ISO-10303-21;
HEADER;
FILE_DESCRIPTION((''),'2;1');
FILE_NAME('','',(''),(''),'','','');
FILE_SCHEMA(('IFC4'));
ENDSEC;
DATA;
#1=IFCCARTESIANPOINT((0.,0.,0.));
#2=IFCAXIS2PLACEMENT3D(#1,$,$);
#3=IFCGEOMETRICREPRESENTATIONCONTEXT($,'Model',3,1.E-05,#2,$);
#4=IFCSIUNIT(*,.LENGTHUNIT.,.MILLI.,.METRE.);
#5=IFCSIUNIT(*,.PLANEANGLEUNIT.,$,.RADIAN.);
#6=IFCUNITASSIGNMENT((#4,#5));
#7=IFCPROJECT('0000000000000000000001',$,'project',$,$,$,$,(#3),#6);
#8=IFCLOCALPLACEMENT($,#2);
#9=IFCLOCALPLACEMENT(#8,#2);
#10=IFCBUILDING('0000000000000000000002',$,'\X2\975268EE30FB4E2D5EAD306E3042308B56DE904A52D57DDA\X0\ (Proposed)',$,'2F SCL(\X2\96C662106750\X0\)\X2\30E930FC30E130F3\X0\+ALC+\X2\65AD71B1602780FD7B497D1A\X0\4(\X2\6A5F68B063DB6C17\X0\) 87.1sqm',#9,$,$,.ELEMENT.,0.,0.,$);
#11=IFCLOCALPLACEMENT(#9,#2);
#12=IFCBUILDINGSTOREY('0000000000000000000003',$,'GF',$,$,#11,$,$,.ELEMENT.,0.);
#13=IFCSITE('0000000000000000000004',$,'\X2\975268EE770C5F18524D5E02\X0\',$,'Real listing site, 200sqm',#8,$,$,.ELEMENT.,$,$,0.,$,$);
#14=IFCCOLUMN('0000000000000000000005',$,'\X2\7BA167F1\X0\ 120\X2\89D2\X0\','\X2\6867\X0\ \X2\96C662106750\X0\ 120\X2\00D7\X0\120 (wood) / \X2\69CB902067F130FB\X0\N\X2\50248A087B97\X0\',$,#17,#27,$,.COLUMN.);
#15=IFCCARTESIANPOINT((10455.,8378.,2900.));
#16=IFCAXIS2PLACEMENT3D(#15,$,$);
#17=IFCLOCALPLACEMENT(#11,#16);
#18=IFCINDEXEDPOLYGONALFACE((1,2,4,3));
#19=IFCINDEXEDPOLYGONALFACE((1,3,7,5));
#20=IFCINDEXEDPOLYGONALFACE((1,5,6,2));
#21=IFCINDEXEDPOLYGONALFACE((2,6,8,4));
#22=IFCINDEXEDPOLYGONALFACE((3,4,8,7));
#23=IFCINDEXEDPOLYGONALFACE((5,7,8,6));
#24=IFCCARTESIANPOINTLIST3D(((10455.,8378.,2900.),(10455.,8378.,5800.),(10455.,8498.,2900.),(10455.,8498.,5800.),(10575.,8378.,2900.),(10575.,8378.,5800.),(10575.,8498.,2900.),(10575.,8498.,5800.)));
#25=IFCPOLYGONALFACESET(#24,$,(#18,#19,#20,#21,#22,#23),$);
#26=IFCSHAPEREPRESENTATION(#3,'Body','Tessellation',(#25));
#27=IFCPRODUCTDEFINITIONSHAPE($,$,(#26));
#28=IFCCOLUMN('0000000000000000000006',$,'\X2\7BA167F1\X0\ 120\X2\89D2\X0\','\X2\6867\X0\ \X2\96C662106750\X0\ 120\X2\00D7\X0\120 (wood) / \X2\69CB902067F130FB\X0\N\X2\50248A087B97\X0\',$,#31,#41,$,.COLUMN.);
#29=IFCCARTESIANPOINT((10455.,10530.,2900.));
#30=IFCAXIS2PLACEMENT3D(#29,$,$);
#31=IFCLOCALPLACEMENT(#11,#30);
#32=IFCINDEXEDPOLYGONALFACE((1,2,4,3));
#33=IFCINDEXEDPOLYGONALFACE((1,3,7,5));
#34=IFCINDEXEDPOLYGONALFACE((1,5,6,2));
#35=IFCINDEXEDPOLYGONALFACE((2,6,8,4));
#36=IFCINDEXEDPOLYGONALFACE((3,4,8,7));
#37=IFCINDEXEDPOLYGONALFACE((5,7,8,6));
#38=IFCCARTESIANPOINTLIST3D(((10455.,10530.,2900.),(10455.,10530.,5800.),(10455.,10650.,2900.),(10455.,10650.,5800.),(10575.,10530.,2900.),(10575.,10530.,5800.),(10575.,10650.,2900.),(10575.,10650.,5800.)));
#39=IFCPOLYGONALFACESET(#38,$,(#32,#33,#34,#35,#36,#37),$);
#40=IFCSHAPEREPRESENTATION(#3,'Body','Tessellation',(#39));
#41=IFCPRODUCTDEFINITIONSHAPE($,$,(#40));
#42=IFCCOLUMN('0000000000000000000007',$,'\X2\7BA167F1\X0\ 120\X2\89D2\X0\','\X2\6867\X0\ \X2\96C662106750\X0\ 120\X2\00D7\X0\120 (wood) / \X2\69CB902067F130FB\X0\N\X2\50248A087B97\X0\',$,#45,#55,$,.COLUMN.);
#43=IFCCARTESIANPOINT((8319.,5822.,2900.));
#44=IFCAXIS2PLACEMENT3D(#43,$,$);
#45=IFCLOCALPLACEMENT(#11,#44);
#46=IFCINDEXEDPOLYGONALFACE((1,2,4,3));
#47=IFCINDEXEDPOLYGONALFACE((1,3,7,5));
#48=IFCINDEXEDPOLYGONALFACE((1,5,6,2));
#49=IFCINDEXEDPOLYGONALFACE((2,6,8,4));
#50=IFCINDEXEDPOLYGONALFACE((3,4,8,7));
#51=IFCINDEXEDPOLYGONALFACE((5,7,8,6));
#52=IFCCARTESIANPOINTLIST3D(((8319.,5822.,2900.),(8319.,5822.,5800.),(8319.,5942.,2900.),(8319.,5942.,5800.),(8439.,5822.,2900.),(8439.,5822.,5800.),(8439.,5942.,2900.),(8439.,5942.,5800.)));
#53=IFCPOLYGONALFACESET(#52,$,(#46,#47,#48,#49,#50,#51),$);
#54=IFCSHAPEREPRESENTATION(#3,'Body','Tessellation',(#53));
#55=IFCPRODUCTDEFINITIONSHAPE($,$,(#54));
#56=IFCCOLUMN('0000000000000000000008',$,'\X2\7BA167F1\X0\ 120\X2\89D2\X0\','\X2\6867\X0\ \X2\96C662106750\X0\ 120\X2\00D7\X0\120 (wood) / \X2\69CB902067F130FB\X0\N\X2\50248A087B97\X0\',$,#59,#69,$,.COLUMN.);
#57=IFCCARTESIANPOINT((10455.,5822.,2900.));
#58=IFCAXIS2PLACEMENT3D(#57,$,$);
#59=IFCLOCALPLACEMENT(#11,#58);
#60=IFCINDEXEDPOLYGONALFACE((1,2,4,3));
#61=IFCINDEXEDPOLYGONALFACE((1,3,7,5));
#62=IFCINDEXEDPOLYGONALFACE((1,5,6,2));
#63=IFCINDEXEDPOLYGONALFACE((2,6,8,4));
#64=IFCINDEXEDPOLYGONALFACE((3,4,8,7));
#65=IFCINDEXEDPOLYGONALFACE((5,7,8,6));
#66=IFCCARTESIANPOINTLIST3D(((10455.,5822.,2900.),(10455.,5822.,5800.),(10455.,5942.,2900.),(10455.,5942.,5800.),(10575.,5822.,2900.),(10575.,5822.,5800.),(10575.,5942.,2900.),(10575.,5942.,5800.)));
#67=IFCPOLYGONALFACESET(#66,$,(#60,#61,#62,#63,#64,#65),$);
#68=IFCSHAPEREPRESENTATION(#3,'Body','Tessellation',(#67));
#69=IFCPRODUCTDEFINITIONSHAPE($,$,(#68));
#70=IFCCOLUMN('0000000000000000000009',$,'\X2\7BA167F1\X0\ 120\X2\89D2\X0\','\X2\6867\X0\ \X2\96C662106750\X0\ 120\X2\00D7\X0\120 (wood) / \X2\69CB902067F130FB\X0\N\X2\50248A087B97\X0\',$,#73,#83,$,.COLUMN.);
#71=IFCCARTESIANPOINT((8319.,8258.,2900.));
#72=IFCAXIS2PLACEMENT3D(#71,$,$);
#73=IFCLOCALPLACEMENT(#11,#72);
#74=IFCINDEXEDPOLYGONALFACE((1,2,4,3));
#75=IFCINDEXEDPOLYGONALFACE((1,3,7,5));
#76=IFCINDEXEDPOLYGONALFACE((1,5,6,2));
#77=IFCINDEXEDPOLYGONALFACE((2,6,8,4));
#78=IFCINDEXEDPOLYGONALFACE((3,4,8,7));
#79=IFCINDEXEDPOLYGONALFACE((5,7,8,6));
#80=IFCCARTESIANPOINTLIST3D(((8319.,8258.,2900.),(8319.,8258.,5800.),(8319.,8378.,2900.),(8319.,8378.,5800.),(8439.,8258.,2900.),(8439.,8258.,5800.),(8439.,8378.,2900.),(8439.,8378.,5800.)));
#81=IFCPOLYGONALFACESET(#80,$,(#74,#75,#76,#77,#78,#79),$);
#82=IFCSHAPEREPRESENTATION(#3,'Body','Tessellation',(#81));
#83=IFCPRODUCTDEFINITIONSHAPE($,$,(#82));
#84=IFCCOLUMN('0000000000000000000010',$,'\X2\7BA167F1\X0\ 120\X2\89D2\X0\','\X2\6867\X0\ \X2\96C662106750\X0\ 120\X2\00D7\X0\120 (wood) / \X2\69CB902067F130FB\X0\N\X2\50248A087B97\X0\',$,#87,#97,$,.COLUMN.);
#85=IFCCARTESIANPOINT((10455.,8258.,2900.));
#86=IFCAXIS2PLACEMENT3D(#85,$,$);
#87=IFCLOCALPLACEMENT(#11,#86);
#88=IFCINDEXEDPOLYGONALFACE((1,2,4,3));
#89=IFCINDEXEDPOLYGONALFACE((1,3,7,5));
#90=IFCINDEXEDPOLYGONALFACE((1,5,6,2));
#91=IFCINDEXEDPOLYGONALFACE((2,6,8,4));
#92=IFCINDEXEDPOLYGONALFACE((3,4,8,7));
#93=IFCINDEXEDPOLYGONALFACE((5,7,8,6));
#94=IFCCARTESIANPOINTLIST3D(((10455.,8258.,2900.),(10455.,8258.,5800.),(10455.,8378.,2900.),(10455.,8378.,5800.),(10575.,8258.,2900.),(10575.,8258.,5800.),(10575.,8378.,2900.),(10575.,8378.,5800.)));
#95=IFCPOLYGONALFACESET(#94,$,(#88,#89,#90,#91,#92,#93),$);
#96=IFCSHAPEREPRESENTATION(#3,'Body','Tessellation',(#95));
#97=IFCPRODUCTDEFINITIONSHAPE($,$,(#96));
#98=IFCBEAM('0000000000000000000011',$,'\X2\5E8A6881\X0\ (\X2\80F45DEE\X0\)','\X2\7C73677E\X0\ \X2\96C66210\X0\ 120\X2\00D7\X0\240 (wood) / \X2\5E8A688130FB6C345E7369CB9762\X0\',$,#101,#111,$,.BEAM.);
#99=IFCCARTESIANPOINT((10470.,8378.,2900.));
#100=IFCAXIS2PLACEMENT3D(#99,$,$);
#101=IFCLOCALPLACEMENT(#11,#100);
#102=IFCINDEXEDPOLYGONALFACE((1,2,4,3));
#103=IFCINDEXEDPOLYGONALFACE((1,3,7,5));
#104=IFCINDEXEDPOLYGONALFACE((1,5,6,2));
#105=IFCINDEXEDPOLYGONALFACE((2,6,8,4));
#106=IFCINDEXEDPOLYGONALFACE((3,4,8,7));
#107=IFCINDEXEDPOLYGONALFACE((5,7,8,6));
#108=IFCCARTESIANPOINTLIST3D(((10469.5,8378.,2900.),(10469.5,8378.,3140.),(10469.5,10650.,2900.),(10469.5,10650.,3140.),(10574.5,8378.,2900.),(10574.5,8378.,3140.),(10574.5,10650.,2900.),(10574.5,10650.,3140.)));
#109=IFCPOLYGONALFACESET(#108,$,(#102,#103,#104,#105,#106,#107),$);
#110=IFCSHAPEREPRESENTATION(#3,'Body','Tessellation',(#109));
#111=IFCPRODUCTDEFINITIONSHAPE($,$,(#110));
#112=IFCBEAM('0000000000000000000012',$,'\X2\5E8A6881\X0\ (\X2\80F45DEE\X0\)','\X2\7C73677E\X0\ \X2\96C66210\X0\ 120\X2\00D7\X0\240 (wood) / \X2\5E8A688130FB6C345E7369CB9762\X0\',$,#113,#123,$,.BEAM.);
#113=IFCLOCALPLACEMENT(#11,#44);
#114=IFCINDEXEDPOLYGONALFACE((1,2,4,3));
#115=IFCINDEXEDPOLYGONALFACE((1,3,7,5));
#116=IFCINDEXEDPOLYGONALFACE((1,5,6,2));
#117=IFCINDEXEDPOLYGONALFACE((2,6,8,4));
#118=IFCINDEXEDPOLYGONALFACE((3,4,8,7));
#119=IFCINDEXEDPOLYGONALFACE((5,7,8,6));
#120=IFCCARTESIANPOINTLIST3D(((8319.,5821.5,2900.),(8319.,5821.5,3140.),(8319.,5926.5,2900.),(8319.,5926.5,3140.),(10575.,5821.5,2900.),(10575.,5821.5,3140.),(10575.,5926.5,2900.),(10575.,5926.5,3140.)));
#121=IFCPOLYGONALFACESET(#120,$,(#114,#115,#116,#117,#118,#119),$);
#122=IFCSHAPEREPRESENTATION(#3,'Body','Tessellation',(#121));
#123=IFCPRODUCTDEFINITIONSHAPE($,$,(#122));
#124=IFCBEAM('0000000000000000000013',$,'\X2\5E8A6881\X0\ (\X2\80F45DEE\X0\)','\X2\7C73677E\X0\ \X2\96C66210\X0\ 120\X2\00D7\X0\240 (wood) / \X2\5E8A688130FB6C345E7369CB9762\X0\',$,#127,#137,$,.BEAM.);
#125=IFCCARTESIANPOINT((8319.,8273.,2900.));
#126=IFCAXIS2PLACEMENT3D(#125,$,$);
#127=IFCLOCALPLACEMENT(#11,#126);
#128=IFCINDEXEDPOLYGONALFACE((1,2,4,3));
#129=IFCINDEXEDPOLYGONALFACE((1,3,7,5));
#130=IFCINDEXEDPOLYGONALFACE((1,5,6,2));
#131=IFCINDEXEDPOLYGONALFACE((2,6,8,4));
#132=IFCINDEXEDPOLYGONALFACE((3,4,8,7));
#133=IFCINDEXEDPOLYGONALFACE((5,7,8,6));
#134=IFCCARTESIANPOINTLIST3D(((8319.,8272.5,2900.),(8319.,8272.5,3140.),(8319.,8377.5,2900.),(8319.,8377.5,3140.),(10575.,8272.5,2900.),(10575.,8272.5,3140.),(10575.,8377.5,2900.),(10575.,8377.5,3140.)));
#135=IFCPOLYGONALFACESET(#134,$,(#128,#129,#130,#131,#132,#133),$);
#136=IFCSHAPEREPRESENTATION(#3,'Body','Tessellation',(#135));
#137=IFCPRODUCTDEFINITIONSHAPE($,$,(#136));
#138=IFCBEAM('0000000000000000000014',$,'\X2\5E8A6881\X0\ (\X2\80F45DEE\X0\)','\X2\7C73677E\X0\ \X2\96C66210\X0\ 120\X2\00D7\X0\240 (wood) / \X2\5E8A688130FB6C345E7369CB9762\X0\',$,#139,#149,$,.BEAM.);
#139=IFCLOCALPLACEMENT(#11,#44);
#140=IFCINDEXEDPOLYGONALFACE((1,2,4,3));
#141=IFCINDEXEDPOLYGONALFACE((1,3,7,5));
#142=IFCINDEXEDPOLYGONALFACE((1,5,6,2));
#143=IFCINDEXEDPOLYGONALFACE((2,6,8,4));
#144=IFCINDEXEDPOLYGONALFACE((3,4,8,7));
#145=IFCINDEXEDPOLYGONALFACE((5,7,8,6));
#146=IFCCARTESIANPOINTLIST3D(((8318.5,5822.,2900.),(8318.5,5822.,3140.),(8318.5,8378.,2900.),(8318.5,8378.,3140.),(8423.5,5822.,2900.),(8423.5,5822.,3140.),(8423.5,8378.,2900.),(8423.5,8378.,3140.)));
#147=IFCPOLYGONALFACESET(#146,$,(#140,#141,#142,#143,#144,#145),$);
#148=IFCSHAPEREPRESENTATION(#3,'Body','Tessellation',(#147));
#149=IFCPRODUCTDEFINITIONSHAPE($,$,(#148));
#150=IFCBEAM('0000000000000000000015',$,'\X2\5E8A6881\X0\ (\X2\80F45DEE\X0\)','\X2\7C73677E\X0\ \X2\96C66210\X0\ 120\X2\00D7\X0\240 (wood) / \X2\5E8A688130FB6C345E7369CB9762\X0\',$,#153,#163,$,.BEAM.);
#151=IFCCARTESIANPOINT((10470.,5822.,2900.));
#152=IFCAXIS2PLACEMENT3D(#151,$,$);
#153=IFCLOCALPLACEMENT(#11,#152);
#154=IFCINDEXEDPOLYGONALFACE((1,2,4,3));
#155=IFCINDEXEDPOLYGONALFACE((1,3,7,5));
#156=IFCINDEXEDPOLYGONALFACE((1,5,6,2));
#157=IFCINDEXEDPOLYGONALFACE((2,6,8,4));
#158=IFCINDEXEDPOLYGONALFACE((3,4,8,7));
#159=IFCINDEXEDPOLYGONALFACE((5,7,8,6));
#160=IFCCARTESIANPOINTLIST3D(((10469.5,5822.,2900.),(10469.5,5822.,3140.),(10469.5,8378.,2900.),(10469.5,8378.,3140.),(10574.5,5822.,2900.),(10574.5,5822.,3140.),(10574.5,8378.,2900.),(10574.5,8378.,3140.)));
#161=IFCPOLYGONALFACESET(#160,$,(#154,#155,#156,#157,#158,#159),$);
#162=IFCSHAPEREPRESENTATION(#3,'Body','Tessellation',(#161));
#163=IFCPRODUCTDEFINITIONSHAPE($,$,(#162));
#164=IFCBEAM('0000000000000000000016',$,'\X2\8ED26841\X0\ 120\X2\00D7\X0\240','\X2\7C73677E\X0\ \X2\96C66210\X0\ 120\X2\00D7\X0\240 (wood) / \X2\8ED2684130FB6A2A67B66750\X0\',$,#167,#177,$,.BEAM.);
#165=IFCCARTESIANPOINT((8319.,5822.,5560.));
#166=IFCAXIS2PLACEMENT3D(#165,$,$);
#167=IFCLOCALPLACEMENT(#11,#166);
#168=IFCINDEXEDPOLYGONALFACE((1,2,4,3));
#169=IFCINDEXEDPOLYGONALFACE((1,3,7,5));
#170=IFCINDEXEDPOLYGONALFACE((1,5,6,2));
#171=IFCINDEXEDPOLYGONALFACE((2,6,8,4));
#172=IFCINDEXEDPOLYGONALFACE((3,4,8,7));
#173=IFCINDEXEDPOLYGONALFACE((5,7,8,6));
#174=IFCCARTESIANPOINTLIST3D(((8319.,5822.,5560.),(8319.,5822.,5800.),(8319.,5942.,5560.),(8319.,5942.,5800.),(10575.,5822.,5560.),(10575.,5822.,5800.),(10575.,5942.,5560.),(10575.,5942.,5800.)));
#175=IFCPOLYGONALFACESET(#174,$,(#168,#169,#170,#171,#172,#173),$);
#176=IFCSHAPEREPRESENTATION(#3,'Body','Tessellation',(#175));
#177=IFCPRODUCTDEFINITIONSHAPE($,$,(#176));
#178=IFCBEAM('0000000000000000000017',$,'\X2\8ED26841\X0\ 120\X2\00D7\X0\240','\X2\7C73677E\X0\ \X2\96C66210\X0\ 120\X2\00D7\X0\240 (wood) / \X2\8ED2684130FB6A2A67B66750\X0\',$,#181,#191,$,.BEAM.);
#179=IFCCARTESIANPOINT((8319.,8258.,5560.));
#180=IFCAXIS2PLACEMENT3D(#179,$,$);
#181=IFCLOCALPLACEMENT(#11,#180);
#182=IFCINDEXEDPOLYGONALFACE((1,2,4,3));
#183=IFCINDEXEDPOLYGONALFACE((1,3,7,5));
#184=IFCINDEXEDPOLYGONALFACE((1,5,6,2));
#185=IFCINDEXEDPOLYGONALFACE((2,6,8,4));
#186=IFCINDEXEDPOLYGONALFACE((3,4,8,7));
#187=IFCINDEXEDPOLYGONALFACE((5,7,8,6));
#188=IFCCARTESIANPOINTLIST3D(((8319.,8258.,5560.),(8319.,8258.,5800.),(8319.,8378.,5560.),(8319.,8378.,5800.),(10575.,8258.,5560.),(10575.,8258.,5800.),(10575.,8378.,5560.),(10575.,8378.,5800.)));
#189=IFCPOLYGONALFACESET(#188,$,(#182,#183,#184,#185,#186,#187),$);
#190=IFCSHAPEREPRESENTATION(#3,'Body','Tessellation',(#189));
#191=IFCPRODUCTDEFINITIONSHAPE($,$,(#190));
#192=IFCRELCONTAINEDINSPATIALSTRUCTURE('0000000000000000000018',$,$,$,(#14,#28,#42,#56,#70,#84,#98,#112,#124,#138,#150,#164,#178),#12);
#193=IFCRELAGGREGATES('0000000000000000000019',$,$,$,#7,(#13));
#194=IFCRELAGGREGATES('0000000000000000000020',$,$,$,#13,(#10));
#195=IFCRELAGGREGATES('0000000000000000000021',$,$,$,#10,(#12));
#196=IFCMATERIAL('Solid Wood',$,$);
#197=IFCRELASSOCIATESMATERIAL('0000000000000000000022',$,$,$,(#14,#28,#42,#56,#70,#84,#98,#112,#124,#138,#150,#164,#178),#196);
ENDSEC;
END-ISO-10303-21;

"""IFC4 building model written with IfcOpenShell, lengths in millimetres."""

from ifc_helpers import new_model, si_unit, frame, frame_2d, origin, place, context, project, spatial, rectangle, extrude, material, element, save


model = new_model("IFC4")

# Units and contexts
model_context = context("Model", 3, precision=1e-05, world=origin())
ifc_project = project(units=[si_unit("LENGTHUNIT", "METRE", prefix="MILLI"), si_unit("PLANEANGLEUNIT", "RADIAN")], contexts=[model_context])

# Site, building, storey
site_placement = place(None, origin())
site = spatial("IfcSite", under=ifc_project, at=site_placement, Name="青森県弘前市", ObjectType="Real listing site, 200sqm", CompositionType="ELEMENT", RefElevation=0.0)
building_placement = place(site_placement, origin())
building = spatial("IfcBuilding", under=site, at=building_placement, Name="青森・中庭のある回遊動線 (Proposed)", ObjectType="2F SCL(集成材)ラーメン+ALC+断熱性能等級4(機械換気) 87.1sqm", CompositionType="ELEMENT", ElevationOfRefHeight=0.0, ElevationOfTerrain=0.0)
storey_placement = place(building_placement, origin())
storey = spatial("IfcBuildingStorey", under=building, at=storey_placement, Name="GF", CompositionType="ELEMENT", Elevation=0.0)

# Columns
ifc_material_1 = material(Name="Solid Wood")
column_1_placement = place(storey_placement, frame((10455.0, 8378.0, 2900.0)))
element("IfcColumn", 1, at=column_1_placement, inside=storey, material=ifc_material_1, Name="管柱 120角", Description="桧 集成材 120×120 (wood) / 構造柱・N値計算", PredefinedType="COLUMN", context=model_context, shape_type="SweptSolid", body=[
    extrude(rectangle(XDim=120.0, YDim=120.0, at=frame_2d((60.0, 60.0))), frame((10455.0, 8378.0, 2900.0)), (0.0, 0.0, 1.0), 2900.0),
])
column_2_placement = place(storey_placement, frame((10455.0, 10530.0, 2900.0)))
element("IfcColumn", 2, at=column_2_placement, inside=storey, material=ifc_material_1, Name="管柱 120角", Description="桧 集成材 120×120 (wood) / 構造柱・N値計算", PredefinedType="COLUMN", context=model_context, shape_type="SweptSolid", body=[
    extrude(rectangle(XDim=120.0, YDim=120.0, at=frame_2d((60.0, 60.0))), frame((10455.0, 10530.0, 2900.0)), (0.0, 0.0, 1.0), 2900.0),
])
column_3_placement = place(storey_placement, frame((8319.0, 5822.0, 2900.0)))
element("IfcColumn", 3, at=column_3_placement, inside=storey, material=ifc_material_1, Name="管柱 120角", Description="桧 集成材 120×120 (wood) / 構造柱・N値計算", PredefinedType="COLUMN", context=model_context, shape_type="SweptSolid", body=[
    extrude(rectangle(XDim=120.0, YDim=120.0, at=frame_2d((60.0, 60.0))), frame((8319.0, 5822.0, 2900.0)), (0.0, 0.0, 1.0), 2900.0),
])
column_4_placement = place(storey_placement, frame((10455.0, 5822.0, 2900.0)))
element("IfcColumn", 4, at=column_4_placement, inside=storey, material=ifc_material_1, Name="管柱 120角", Description="桧 集成材 120×120 (wood) / 構造柱・N値計算", PredefinedType="COLUMN", context=model_context, shape_type="SweptSolid", body=[
    extrude(rectangle(XDim=120.0, YDim=120.0, at=frame_2d((60.0, 60.0))), frame((10455.0, 5822.0, 2900.0)), (0.0, 0.0, 1.0), 2900.0),
])
column_5_placement = place(storey_placement, frame((8319.0, 8258.0, 2900.0)))
element("IfcColumn", 5, at=column_5_placement, inside=storey, material=ifc_material_1, Name="管柱 120角", Description="桧 集成材 120×120 (wood) / 構造柱・N値計算", PredefinedType="COLUMN", context=model_context, shape_type="SweptSolid", body=[
    extrude(rectangle(XDim=120.0, YDim=120.0, at=frame_2d((60.0, 60.0))), frame((8319.0, 8258.0, 2900.0)), (0.0, 0.0, 1.0), 2900.0),
])
column_6_placement = place(storey_placement, frame((10455.0, 8258.0, 2900.0)))
element("IfcColumn", 6, at=column_6_placement, inside=storey, material=ifc_material_1, Name="管柱 120角", Description="桧 集成材 120×120 (wood) / 構造柱・N値計算", PredefinedType="COLUMN", context=model_context, shape_type="SweptSolid", body=[
    extrude(rectangle(XDim=120.0, YDim=120.0, at=frame_2d((60.0, 60.0))), frame((10455.0, 8258.0, 2900.0)), (0.0, 0.0, 1.0), 2900.0),
])

# Beams
beam_1_placement = place(storey_placement, frame((10470.0, 8378.0, 2900.0)))
element("IfcBeam", 7, at=beam_1_placement, inside=storey, material=ifc_material_1, Name="床梁 (胴差)", Description="米松 集成 120×240 (wood) / 床梁・水平構面", PredefinedType="BEAM", context=model_context, shape_type="SweptSolid", body=[
    extrude(rectangle(XDim=105.0, YDim=2272.0, at=frame_2d((52.0, 1136.0))), frame((10470.0, 8378.0, 2900.0)), (0.0, 0.0, 1.0), 240.0),
])
beam_2_placement = place(storey_placement, frame((8319.0, 5822.0, 2900.0)))
element("IfcBeam", 8, at=beam_2_placement, inside=storey, material=ifc_material_1, Name="床梁 (胴差)", Description="米松 集成 120×240 (wood) / 床梁・水平構面", PredefinedType="BEAM", context=model_context, shape_type="SweptSolid", body=[
    extrude(rectangle(XDim=2256.0, YDim=105.0, at=frame_2d((1128.0, 52.0))), frame((8319.0, 5822.0, 2900.0)), (0.0, 0.0, 1.0), 240.0),
])
beam_3_placement = place(storey_placement, frame((8319.0, 8273.0, 2900.0)))
element("IfcBeam", 9, at=beam_3_placement, inside=storey, material=ifc_material_1, Name="床梁 (胴差)", Description="米松 集成 120×240 (wood) / 床梁・水平構面", PredefinedType="BEAM", context=model_context, shape_type="SweptSolid", body=[
    extrude(rectangle(XDim=2256.0, YDim=105.0, at=frame_2d((1128.0, 52.0))), frame((8319.0, 8273.0, 2900.0)), (0.0, 0.0, 1.0), 240.0),
])
beam_4_placement = place(storey_placement, frame((8319.0, 5822.0, 2900.0)))
element("IfcBeam", 10, at=beam_4_placement, inside=storey, material=ifc_material_1, Name="床梁 (胴差)", Description="米松 集成 120×240 (wood) / 床梁・水平構面", PredefinedType="BEAM", context=model_context, shape_type="SweptSolid", body=[
    extrude(rectangle(XDim=105.0, YDim=2556.0, at=frame_2d((52.0, 1278.0))), frame((8319.0, 5822.0, 2900.0)), (0.0, 0.0, 1.0), 240.0),
])
beam_5_placement = place(storey_placement, frame((10470.0, 5822.0, 2900.0)))
element("IfcBeam", 11, at=beam_5_placement, inside=storey, material=ifc_material_1, Name="床梁 (胴差)", Description="米松 集成 120×240 (wood) / 床梁・水平構面", PredefinedType="BEAM", context=model_context, shape_type="SweptSolid", body=[
    extrude(rectangle(XDim=105.0, YDim=2556.0, at=frame_2d((52.0, 1278.0))), frame((10470.0, 5822.0, 2900.0)), (0.0, 0.0, 1.0), 240.0),
])
beam_6_placement = place(storey_placement, frame((8319.0, 5822.0, 5560.0)))
element("IfcBeam", 12, at=beam_6_placement, inside=storey, material=ifc_material_1, Name="軒桁 120×240", Description="米松 集成 120×240 (wood) / 軒桁・横架材", PredefinedType="BEAM", context=model_context, shape_type="SweptSolid", body=[
    extrude(rectangle(XDim=2256.0, YDim=120.0, at=frame_2d((1128.0, 60.0))), frame((8319.0, 5822.0, 5560.0)), (0.0, 0.0, 1.0), 240.0),
])
beam_7_placement = place(storey_placement, frame((8319.0, 8258.0, 5560.0)))
element("IfcBeam", 13, at=beam_7_placement, inside=storey, material=ifc_material_1, Name="軒桁 120×240", Description="米松 集成 120×240 (wood) / 軒桁・横架材", PredefinedType="BEAM", context=model_context, shape_type="SweptSolid", body=[
    extrude(rectangle(XDim=2256.0, YDim=120.0, at=frame_2d((1128.0, 60.0))), frame((8319.0, 8258.0, 5560.0)), (0.0, 0.0, 1.0), 240.0),
])

save(model, "model.ifc")
